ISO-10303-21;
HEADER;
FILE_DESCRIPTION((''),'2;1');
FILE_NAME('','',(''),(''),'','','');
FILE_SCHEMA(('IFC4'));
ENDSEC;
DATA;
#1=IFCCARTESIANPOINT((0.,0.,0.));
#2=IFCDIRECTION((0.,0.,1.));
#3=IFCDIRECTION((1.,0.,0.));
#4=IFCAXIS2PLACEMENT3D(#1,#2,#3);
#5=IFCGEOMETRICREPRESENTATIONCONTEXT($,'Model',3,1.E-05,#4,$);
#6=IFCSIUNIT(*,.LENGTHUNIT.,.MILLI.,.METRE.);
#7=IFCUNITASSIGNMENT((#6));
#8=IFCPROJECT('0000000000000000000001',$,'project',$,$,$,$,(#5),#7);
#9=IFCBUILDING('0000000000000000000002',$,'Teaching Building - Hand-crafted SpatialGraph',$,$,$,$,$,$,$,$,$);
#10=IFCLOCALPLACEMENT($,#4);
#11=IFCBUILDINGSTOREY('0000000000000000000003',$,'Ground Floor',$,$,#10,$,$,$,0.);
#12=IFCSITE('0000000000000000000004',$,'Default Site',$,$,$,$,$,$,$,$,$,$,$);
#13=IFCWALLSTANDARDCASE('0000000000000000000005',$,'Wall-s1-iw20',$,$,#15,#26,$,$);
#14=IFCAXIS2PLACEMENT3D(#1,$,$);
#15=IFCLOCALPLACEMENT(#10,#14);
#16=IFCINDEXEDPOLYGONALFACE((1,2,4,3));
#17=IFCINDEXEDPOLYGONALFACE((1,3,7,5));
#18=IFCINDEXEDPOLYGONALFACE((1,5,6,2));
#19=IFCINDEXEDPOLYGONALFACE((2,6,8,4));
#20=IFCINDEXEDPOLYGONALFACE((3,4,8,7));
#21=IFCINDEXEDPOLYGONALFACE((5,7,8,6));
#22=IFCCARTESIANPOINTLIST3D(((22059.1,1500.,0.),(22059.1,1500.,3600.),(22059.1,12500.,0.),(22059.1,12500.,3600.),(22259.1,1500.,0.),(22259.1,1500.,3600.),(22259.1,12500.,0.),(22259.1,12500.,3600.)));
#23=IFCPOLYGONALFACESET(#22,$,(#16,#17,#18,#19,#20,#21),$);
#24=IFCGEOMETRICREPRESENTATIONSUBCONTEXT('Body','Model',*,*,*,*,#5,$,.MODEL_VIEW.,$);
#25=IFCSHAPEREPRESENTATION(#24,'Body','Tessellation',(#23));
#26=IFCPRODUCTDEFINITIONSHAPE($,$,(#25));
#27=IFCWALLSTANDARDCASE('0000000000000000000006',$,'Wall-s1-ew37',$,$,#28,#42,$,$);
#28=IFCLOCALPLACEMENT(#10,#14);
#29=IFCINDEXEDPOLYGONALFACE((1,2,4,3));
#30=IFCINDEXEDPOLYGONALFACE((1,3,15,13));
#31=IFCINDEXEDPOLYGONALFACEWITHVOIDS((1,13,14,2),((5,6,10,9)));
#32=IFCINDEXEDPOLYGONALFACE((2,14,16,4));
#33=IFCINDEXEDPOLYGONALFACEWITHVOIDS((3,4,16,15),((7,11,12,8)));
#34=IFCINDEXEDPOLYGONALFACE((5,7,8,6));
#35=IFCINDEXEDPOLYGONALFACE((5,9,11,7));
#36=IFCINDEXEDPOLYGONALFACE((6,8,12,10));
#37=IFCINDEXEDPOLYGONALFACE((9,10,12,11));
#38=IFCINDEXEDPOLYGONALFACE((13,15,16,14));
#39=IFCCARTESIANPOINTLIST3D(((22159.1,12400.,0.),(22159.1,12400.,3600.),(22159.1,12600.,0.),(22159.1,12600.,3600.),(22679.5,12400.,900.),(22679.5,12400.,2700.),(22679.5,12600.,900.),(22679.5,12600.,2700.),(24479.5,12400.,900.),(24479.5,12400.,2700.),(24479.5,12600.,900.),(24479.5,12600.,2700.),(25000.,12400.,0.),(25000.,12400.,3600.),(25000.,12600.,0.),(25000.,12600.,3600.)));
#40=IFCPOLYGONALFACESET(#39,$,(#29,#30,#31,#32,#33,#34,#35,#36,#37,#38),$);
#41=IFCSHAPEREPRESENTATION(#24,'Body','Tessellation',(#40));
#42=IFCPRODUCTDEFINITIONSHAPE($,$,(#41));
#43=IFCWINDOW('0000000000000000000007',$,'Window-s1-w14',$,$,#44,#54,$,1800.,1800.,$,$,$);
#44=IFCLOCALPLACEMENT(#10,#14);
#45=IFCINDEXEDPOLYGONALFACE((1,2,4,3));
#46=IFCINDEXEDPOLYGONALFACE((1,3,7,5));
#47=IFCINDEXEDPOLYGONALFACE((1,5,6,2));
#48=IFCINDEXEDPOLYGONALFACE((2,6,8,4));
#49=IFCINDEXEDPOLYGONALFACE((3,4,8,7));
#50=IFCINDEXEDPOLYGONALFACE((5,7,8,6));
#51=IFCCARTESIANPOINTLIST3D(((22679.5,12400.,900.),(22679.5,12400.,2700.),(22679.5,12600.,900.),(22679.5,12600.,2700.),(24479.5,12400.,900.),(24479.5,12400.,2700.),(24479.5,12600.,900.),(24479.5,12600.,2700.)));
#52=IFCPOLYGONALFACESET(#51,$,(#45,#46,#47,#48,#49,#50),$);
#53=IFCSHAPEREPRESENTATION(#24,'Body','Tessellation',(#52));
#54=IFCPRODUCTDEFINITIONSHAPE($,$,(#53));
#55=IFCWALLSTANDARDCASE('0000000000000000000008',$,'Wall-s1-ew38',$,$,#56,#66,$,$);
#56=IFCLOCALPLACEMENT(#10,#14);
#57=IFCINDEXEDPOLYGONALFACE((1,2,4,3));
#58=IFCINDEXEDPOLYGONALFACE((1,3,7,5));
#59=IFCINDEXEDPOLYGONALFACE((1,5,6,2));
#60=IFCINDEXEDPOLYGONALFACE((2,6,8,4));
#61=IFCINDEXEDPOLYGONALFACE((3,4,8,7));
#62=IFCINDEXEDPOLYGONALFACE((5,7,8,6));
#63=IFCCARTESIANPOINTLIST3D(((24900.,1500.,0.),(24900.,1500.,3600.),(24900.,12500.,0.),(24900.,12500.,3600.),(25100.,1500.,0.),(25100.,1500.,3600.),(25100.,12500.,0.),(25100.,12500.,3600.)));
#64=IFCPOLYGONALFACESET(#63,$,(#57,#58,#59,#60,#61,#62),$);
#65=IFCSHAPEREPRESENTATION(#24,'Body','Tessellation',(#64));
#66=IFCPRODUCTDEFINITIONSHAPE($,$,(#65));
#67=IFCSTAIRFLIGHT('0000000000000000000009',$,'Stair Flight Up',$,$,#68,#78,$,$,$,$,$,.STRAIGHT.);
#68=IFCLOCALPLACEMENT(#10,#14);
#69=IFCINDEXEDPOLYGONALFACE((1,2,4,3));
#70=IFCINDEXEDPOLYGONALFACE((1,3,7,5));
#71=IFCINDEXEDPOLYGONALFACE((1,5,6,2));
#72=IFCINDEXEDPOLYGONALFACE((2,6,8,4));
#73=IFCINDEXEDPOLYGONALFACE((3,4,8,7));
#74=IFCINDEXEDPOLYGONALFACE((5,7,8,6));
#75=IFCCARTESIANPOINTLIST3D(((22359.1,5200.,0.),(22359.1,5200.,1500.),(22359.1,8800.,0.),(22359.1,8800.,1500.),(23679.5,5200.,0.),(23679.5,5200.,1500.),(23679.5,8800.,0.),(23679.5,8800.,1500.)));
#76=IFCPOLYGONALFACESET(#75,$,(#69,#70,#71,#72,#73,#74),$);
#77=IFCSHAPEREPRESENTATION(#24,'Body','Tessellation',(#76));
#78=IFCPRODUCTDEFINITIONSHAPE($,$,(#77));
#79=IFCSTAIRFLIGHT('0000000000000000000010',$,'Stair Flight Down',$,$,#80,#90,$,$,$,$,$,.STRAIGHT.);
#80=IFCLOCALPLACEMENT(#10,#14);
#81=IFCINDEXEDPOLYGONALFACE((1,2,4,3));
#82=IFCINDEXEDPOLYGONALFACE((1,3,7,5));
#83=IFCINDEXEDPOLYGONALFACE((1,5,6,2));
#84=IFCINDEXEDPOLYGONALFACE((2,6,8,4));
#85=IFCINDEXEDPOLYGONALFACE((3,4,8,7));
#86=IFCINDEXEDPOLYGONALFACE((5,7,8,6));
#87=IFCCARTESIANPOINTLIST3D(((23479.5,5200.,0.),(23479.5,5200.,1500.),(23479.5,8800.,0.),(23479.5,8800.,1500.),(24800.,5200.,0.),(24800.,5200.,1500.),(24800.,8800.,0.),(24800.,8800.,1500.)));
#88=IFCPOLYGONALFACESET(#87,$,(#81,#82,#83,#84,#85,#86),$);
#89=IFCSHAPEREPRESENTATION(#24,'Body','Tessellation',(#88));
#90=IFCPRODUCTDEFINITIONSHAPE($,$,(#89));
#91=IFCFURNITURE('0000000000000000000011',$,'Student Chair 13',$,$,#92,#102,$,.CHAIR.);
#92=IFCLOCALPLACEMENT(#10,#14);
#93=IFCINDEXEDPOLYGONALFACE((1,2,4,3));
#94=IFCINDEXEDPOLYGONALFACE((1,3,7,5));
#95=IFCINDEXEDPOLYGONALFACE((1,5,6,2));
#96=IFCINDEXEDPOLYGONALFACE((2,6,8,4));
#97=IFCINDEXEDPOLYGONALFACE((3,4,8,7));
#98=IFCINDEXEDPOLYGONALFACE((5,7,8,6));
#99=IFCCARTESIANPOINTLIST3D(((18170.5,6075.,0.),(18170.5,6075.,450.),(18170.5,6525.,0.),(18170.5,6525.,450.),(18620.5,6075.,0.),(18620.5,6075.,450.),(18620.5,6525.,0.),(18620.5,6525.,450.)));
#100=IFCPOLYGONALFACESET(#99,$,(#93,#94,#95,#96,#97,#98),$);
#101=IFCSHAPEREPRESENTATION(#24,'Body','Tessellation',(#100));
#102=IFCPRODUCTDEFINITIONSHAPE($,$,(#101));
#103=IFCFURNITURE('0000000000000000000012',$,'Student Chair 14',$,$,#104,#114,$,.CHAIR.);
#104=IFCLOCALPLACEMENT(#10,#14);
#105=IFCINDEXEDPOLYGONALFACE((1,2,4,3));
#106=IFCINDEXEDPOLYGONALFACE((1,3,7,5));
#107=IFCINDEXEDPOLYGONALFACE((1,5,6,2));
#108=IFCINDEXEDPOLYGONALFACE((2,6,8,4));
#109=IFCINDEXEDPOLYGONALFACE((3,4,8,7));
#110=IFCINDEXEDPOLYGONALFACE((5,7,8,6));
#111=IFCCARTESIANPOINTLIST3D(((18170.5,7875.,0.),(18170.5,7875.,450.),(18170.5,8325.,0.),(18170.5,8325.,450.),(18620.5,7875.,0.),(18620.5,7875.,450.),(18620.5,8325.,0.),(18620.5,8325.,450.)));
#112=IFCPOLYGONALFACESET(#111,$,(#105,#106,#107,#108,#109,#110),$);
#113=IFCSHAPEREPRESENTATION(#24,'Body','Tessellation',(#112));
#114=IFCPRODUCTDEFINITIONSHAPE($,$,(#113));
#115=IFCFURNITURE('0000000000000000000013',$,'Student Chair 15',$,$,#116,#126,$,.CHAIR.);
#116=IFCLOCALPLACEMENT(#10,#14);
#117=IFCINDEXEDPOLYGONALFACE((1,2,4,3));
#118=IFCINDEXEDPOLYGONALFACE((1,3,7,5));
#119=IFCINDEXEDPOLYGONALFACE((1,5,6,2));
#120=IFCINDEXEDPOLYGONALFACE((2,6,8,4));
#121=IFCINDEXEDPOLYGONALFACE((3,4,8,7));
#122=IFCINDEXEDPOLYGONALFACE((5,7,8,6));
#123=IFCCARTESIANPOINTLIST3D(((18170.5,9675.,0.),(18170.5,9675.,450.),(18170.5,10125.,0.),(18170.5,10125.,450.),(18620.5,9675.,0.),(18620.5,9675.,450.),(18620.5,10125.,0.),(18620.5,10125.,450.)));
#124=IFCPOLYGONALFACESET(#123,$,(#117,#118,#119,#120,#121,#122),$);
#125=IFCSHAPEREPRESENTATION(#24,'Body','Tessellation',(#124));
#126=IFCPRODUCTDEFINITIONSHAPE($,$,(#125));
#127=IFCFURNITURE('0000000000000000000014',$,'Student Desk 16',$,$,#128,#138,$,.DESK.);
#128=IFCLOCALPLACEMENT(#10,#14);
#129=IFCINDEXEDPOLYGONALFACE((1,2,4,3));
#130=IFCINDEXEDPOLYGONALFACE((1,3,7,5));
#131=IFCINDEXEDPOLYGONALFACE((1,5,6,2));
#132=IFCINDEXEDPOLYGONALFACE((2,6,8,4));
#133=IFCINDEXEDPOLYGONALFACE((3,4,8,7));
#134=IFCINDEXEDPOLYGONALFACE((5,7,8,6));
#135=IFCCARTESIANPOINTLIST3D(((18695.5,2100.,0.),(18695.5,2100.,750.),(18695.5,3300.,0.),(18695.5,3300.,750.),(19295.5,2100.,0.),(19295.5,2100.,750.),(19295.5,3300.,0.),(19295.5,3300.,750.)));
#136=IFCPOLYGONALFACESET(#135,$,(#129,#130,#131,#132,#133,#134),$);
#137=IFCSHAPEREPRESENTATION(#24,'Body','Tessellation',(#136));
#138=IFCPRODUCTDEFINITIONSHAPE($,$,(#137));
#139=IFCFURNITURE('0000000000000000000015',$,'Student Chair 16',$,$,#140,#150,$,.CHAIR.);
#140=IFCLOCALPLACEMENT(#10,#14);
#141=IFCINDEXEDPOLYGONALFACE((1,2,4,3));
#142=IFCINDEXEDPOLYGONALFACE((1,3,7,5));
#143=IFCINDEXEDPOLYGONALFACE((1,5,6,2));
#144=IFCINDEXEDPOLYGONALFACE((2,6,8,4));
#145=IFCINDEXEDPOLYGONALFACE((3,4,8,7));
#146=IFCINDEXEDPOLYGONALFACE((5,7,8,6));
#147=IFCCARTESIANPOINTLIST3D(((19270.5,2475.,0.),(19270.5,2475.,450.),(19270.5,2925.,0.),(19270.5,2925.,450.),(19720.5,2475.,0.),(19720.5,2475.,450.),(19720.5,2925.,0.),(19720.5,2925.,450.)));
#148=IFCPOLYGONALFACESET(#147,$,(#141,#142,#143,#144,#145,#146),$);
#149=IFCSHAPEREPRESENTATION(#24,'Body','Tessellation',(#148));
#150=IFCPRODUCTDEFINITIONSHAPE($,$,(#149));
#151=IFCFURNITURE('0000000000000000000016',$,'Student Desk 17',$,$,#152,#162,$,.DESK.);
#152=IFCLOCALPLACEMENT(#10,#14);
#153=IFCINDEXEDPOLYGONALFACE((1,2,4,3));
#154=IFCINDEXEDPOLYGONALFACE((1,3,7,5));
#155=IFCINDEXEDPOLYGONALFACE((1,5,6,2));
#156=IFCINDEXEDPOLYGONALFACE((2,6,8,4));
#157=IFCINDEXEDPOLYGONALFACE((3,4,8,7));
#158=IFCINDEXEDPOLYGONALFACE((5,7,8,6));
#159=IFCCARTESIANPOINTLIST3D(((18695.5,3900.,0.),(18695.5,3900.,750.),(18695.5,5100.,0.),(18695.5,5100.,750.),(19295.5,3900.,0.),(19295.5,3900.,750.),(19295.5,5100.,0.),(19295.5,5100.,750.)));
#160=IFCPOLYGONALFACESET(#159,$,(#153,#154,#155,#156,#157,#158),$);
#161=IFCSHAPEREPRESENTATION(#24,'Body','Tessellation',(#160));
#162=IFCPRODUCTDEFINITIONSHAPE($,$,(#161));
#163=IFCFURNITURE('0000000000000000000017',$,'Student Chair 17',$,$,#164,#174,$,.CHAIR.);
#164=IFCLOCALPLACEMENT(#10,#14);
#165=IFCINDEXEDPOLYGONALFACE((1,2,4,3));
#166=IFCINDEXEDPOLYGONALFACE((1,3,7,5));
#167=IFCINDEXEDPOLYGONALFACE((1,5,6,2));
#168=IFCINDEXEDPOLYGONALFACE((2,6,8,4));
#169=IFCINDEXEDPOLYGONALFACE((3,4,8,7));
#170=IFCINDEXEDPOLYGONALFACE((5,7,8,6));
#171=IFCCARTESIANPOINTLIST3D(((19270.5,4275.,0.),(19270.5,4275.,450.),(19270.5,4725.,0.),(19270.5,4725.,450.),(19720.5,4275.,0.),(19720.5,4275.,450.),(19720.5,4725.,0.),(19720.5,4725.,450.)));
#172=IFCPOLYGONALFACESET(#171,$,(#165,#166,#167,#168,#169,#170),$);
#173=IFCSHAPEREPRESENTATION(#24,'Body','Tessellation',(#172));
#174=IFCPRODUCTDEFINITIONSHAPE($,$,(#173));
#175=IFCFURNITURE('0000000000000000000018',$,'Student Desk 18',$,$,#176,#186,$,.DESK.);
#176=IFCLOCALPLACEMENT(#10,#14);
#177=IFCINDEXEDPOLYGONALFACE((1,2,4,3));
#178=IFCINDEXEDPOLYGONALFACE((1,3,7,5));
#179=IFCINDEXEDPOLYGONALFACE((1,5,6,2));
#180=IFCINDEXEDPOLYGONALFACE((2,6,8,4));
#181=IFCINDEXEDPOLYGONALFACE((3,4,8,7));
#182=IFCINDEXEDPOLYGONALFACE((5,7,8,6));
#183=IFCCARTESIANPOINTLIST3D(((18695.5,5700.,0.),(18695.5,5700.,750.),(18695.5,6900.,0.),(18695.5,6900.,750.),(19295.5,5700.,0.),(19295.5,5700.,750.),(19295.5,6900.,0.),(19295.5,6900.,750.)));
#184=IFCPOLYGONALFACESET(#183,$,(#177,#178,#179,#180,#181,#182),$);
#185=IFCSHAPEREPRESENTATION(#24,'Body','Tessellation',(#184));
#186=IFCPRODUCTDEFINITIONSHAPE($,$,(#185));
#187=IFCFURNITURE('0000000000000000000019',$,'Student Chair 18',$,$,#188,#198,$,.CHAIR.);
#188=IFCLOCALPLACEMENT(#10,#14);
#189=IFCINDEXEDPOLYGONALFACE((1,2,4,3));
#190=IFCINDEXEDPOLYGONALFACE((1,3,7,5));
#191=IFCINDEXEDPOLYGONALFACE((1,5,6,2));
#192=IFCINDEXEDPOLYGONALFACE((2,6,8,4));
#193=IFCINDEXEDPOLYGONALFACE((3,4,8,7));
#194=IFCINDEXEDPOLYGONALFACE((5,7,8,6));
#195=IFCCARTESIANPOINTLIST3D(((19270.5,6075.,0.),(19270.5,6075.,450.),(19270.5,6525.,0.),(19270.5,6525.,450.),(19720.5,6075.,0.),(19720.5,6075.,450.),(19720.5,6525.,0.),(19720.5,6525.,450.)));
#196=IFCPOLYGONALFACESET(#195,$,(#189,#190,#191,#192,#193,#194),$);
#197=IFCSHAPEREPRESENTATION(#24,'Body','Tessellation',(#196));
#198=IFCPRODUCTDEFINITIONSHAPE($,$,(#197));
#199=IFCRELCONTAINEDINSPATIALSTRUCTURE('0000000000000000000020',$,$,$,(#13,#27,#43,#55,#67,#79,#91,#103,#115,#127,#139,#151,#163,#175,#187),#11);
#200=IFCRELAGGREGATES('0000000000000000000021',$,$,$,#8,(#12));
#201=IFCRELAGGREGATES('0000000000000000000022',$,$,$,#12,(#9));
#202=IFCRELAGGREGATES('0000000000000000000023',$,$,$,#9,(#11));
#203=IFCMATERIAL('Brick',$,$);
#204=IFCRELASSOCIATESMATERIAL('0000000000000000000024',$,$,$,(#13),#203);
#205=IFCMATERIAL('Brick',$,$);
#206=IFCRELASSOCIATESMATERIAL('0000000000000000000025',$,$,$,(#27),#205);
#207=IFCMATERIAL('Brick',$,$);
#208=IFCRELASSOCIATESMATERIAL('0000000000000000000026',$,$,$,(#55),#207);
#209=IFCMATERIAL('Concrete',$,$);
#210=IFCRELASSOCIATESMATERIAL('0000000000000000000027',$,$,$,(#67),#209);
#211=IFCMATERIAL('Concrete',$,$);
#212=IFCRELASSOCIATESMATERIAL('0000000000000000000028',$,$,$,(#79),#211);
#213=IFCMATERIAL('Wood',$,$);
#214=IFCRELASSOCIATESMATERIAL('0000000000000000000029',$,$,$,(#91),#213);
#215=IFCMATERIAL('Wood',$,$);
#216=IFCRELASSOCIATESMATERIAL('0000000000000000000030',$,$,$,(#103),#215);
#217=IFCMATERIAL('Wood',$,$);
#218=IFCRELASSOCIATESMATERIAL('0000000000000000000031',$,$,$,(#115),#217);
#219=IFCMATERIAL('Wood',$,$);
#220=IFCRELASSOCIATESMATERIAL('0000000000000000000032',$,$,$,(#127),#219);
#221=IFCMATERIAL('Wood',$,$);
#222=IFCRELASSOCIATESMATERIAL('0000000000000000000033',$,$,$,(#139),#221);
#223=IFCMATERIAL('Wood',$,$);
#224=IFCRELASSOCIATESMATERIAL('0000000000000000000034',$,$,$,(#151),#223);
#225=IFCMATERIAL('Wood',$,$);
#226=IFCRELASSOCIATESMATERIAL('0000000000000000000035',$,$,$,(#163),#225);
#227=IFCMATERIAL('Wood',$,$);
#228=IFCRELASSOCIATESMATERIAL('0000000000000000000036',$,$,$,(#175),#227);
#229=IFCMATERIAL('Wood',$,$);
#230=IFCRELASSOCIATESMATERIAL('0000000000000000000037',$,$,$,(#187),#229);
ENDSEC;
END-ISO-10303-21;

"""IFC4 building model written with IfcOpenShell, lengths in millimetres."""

from ifc_helpers import new_model, si_unit, frame, frame_2d, origin_with_axes, origin_2d, place, context, subcontext, project, spatial, rectangle, extrude, material, element, fill, save


model = new_model("IFC4")

# Units and contexts
model_context = context("Model", 3, precision=1e-05, world=origin_with_axes())
body_context = subcontext(model_context, "Body", "Model", "MODEL_VIEW")
ifc_project = project(units=[si_unit("LENGTHUNIT", "METRE", prefix="MILLI")], contexts=[model_context])

# Site, building, storey
site = spatial("IfcSite", under=ifc_project, Name="Default Site")
building = spatial("IfcBuilding", under=site, Name="Teaching Building - Hand-crafted SpatialGraph")
storey_placement = place(None, origin_with_axes())
storey = spatial("IfcBuildingStorey", under=building, at=storey_placement, Name="Ground Floor", Elevation=0.0)

# Wall
ifc_material_1 = material(Name="Brick")
wall_1_placement = place(storey_placement, frame((22159.1, 1500.0, 0.0), z_axis=(0.0, 0.0, 1.0), x_axis=(0.0, 1.0, 0.0)))
element("IfcWallStandardCase", 1, at=wall_1_placement, inside=storey, material=ifc_material_1, Name="Wall-s1-iw20", context=body_context, shape_type="SweptSolid", body=[
    extrude(rectangle(XDim=11000.0, YDim=200.0, at=frame_2d((5500.0, 0.0))), origin_with_axes(), (0.0, 0.0, 1.0), 3600.0),
])

# Wall, opening, window
ifc_material_2 = material(Name="Brick")
wall_2_placement = place(storey_placement, frame((22159.1, 12500.0, 0.0), z_axis=(0.0, 0.0, 1.0), x_axis=(1.0, 0.0, 0.0)))
wall_2 = element("IfcWallStandardCase", 2, at=wall_2_placement, inside=storey, material=ifc_material_2, Name="Wall-s1-ew37", context=body_context, shape_type="SweptSolid", body=[
    extrude(rectangle(XDim=2840.9, YDim=200.0, at=frame_2d((1420.5, 0.0))), origin_with_axes(), (0.0, 0.0, 1.0), 3600.0),
])
opening_placement = place(wall_2_placement, frame((520.5, 0.0, 900.0), z_axis=(0.0, 0.0, 1.0), x_axis=(1.0, 0.0, 0.0)))
opening = element("IfcOpeningElement", 3, at=opening_placement, cuts=wall_2, context=body_context, shape_type="SweptSolid", body=[
    extrude(rectangle(XDim=1800.0, YDim=400.0, at=frame_2d((900.0, 0.0))), origin_with_axes(), (0.0, 0.0, 1.0), 1800.0),
])
window_placement = place(storey_placement, frame((22679.5, 12500.0, 900.0), z_axis=(0.0, 0.0, 1.0), x_axis=(1.0, 0.0, 0.0)))
window = element("IfcWindow", 4, at=window_placement, inside=storey, Name="Window-s1-w14", OverallHeight=1800.0, OverallWidth=1800.0, context=body_context, shape_type="SweptSolid", body=[
    extrude(rectangle(XDim=1800.0, YDim=200.0, at=frame_2d((900.0, 0.0))), origin_with_axes(), (0.0, 0.0, 1.0), 1800.0),
])
fill(opening, window)

# Wall
ifc_material_3 = material(Name="Brick")
wall_3_placement = place(storey_placement, frame((25000.0, 1500.0, 0.0), z_axis=(0.0, 0.0, 1.0), x_axis=(0.0, 1.0, 0.0)))
element("IfcWallStandardCase", 5, at=wall_3_placement, inside=storey, material=ifc_material_3, Name="Wall-s1-ew38", context=body_context, shape_type="SweptSolid", body=[
    extrude(rectangle(XDim=11000.0, YDim=200.0, at=frame_2d((5500.0, 0.0))), origin_with_axes(), (0.0, 0.0, 1.0), 3600.0),
])

# Stair flights
ifc_material_4 = material(Name="Concrete")
stair_flight_1_placement = place(storey_placement, frame((23019.3, 7000.0, 0.0), z_axis=(0.0, 0.0, 1.0), x_axis=(1.0, 0.0, 0.0)))
element("IfcStairFlight", 6, at=stair_flight_1_placement, inside=storey, material=ifc_material_4, Name="Stair Flight Up", PredefinedType="STRAIGHT", context=body_context, shape_type="SweptSolid", body=[
    extrude(rectangle(XDim=1320.5, YDim=3600.0, at=origin_2d()), origin_with_axes(), (0.0, 0.0, 1.0), 1500.0),
])
ifc_material_5 = material(Name="Concrete")
stair_flight_2_placement = place(storey_placement, frame((24139.8, 7000.0, 0.0), z_axis=(0.0, 0.0, 1.0), x_axis=(1.0, 0.0, 0.0)))
element("IfcStairFlight", 7, at=stair_flight_2_placement, inside=storey, material=ifc_material_5, Name="Stair Flight Down", PredefinedType="STRAIGHT", context=body_context, shape_type="SweptSolid", body=[
    extrude(rectangle(XDim=1320.5, YDim=3600.0, at=origin_2d()), origin_with_axes(), (0.0, 0.0, 1.0), 1500.0),
])

# Furniture
ifc_material_6 = material(Name="Wood")
furniture_1_placement = place(storey_placement, frame((18395.5, 6300.0, 0.0), z_axis=(0.0, 0.0, 1.0), x_axis=(1.0, 0.0, 0.0)))
element("IfcFurniture", 8, at=furniture_1_placement, inside=storey, material=ifc_material_6, Name="Student Chair 13", PredefinedType="CHAIR", context=body_context, shape_type="SweptSolid", body=[
    extrude(rectangle(XDim=450.0, YDim=450.0, at=origin_2d()), origin_with_axes(), (0.0, 0.0, 1.0), 450.0),
])
ifc_material_7 = material(Name="Wood")
furniture_2_placement = place(storey_placement, frame((18395.5, 8100.0, 0.0), z_axis=(0.0, 0.0, 1.0), x_axis=(1.0, 0.0, 0.0)))
element("IfcFurniture", 9, at=furniture_2_placement, inside=storey, material=ifc_material_7, Name="Student Chair 14", PredefinedType="CHAIR", context=body_context, shape_type="SweptSolid", body=[
    extrude(rectangle(XDim=450.0, YDim=450.0, at=origin_2d()), origin_with_axes(), (0.0, 0.0, 1.0), 450.0),
])
ifc_material_8 = material(Name="Wood")
furniture_3_placement = place(storey_placement, frame((18395.5, 9900.0, 0.0), z_axis=(0.0, 0.0, 1.0), x_axis=(1.0, 0.0, 0.0)))
element("IfcFurniture", 10, at=furniture_3_placement, inside=storey, material=ifc_material_8, Name="Student Chair 15", PredefinedType="CHAIR", context=body_context, shape_type="SweptSolid", body=[
    extrude(rectangle(XDim=450.0, YDim=450.0, at=origin_2d()), origin_with_axes(), (0.0, 0.0, 1.0), 450.0),
])
ifc_material_9 = material(Name="Wood")
furniture_4_placement = place(storey_placement, frame((18995.5, 2700.0, 0.0), z_axis=(0.0, 0.0, 1.0), x_axis=(0.0, 1.0, 0.0)))
element("IfcFurniture", 11, at=furniture_4_placement, inside=storey, material=ifc_material_9, Name="Student Desk 16", PredefinedType="DESK", context=body_context, shape_type="SweptSolid", body=[
    extrude(rectangle(XDim=1200.0, YDim=600.0, at=origin_2d()), origin_with_axes(), (0.0, 0.0, 1.0), 750.0),
])
ifc_material_10 = material(Name="Wood")
furniture_5_placement = place(storey_placement, frame((19495.5, 2700.0, 0.0), z_axis=(0.0, 0.0, 1.0), x_axis=(1.0, 0.0, 0.0)))
element("IfcFurniture", 12, at=furniture_5_placement, inside=storey, material=ifc_material_10, Name="Student Chair 16", PredefinedType="CHAIR", context=body_context, shape_type="SweptSolid", body=[
    extrude(rectangle(XDim=450.0, YDim=450.0, at=origin_2d()), origin_with_axes(), (0.0, 0.0, 1.0), 450.0),
])
ifc_material_11 = material(Name="Wood")
furniture_6_placement = place(storey_placement, frame((18995.5, 4500.0, 0.0), z_axis=(0.0, 0.0, 1.0), x_axis=(0.0, 1.0, 0.0)))
element("IfcFurniture", 13, at=furniture_6_placement, inside=storey, material=ifc_material_11, Name="Student Desk 17", PredefinedType="DESK", context=body_context, shape_type="SweptSolid", body=[
    extrude(rectangle(XDim=1200.0, YDim=600.0, at=origin_2d()), origin_with_axes(), (0.0, 0.0, 1.0), 750.0),
])
ifc_material_12 = material(Name="Wood")
furniture_7_placement = place(storey_placement, frame((19495.5, 4500.0, 0.0), z_axis=(0.0, 0.0, 1.0), x_axis=(1.0, 0.0, 0.0)))
element("IfcFurniture", 14, at=furniture_7_placement, inside=storey, material=ifc_material_12, Name="Student Chair 17", PredefinedType="CHAIR", context=body_context, shape_type="SweptSolid", body=[
    extrude(rectangle(XDim=450.0, YDim=450.0, at=origin_2d()), origin_with_axes(), (0.0, 0.0, 1.0), 450.0),
])
ifc_material_13 = material(Name="Wood")
furniture_8_placement = place(storey_placement, frame((18995.5, 6300.0, 0.0), z_axis=(0.0, 0.0, 1.0), x_axis=(0.0, 1.0, 0.0)))
element("IfcFurniture", 15, at=furniture_8_placement, inside=storey, material=ifc_material_13, Name="Student Desk 18", PredefinedType="DESK", context=body_context, shape_type="SweptSolid", body=[
    extrude(rectangle(XDim=1200.0, YDim=600.0, at=origin_2d()), origin_with_axes(), (0.0, 0.0, 1.0), 750.0),
])
ifc_material_14 = material(Name="Wood")
furniture_9_placement = place(storey_placement, frame((19495.5, 6300.0, 0.0), z_axis=(0.0, 0.0, 1.0), x_axis=(1.0, 0.0, 0.0)))
element("IfcFurniture", 16, at=furniture_9_placement, inside=storey, material=ifc_material_14, Name="Student Chair 18", PredefinedType="CHAIR", context=body_context, shape_type="SweptSolid", body=[
    extrude(rectangle(XDim=450.0, YDim=450.0, at=origin_2d()), origin_with_axes(), (0.0, 0.0, 1.0), 450.0),
])

save(model, "model.ifc")
